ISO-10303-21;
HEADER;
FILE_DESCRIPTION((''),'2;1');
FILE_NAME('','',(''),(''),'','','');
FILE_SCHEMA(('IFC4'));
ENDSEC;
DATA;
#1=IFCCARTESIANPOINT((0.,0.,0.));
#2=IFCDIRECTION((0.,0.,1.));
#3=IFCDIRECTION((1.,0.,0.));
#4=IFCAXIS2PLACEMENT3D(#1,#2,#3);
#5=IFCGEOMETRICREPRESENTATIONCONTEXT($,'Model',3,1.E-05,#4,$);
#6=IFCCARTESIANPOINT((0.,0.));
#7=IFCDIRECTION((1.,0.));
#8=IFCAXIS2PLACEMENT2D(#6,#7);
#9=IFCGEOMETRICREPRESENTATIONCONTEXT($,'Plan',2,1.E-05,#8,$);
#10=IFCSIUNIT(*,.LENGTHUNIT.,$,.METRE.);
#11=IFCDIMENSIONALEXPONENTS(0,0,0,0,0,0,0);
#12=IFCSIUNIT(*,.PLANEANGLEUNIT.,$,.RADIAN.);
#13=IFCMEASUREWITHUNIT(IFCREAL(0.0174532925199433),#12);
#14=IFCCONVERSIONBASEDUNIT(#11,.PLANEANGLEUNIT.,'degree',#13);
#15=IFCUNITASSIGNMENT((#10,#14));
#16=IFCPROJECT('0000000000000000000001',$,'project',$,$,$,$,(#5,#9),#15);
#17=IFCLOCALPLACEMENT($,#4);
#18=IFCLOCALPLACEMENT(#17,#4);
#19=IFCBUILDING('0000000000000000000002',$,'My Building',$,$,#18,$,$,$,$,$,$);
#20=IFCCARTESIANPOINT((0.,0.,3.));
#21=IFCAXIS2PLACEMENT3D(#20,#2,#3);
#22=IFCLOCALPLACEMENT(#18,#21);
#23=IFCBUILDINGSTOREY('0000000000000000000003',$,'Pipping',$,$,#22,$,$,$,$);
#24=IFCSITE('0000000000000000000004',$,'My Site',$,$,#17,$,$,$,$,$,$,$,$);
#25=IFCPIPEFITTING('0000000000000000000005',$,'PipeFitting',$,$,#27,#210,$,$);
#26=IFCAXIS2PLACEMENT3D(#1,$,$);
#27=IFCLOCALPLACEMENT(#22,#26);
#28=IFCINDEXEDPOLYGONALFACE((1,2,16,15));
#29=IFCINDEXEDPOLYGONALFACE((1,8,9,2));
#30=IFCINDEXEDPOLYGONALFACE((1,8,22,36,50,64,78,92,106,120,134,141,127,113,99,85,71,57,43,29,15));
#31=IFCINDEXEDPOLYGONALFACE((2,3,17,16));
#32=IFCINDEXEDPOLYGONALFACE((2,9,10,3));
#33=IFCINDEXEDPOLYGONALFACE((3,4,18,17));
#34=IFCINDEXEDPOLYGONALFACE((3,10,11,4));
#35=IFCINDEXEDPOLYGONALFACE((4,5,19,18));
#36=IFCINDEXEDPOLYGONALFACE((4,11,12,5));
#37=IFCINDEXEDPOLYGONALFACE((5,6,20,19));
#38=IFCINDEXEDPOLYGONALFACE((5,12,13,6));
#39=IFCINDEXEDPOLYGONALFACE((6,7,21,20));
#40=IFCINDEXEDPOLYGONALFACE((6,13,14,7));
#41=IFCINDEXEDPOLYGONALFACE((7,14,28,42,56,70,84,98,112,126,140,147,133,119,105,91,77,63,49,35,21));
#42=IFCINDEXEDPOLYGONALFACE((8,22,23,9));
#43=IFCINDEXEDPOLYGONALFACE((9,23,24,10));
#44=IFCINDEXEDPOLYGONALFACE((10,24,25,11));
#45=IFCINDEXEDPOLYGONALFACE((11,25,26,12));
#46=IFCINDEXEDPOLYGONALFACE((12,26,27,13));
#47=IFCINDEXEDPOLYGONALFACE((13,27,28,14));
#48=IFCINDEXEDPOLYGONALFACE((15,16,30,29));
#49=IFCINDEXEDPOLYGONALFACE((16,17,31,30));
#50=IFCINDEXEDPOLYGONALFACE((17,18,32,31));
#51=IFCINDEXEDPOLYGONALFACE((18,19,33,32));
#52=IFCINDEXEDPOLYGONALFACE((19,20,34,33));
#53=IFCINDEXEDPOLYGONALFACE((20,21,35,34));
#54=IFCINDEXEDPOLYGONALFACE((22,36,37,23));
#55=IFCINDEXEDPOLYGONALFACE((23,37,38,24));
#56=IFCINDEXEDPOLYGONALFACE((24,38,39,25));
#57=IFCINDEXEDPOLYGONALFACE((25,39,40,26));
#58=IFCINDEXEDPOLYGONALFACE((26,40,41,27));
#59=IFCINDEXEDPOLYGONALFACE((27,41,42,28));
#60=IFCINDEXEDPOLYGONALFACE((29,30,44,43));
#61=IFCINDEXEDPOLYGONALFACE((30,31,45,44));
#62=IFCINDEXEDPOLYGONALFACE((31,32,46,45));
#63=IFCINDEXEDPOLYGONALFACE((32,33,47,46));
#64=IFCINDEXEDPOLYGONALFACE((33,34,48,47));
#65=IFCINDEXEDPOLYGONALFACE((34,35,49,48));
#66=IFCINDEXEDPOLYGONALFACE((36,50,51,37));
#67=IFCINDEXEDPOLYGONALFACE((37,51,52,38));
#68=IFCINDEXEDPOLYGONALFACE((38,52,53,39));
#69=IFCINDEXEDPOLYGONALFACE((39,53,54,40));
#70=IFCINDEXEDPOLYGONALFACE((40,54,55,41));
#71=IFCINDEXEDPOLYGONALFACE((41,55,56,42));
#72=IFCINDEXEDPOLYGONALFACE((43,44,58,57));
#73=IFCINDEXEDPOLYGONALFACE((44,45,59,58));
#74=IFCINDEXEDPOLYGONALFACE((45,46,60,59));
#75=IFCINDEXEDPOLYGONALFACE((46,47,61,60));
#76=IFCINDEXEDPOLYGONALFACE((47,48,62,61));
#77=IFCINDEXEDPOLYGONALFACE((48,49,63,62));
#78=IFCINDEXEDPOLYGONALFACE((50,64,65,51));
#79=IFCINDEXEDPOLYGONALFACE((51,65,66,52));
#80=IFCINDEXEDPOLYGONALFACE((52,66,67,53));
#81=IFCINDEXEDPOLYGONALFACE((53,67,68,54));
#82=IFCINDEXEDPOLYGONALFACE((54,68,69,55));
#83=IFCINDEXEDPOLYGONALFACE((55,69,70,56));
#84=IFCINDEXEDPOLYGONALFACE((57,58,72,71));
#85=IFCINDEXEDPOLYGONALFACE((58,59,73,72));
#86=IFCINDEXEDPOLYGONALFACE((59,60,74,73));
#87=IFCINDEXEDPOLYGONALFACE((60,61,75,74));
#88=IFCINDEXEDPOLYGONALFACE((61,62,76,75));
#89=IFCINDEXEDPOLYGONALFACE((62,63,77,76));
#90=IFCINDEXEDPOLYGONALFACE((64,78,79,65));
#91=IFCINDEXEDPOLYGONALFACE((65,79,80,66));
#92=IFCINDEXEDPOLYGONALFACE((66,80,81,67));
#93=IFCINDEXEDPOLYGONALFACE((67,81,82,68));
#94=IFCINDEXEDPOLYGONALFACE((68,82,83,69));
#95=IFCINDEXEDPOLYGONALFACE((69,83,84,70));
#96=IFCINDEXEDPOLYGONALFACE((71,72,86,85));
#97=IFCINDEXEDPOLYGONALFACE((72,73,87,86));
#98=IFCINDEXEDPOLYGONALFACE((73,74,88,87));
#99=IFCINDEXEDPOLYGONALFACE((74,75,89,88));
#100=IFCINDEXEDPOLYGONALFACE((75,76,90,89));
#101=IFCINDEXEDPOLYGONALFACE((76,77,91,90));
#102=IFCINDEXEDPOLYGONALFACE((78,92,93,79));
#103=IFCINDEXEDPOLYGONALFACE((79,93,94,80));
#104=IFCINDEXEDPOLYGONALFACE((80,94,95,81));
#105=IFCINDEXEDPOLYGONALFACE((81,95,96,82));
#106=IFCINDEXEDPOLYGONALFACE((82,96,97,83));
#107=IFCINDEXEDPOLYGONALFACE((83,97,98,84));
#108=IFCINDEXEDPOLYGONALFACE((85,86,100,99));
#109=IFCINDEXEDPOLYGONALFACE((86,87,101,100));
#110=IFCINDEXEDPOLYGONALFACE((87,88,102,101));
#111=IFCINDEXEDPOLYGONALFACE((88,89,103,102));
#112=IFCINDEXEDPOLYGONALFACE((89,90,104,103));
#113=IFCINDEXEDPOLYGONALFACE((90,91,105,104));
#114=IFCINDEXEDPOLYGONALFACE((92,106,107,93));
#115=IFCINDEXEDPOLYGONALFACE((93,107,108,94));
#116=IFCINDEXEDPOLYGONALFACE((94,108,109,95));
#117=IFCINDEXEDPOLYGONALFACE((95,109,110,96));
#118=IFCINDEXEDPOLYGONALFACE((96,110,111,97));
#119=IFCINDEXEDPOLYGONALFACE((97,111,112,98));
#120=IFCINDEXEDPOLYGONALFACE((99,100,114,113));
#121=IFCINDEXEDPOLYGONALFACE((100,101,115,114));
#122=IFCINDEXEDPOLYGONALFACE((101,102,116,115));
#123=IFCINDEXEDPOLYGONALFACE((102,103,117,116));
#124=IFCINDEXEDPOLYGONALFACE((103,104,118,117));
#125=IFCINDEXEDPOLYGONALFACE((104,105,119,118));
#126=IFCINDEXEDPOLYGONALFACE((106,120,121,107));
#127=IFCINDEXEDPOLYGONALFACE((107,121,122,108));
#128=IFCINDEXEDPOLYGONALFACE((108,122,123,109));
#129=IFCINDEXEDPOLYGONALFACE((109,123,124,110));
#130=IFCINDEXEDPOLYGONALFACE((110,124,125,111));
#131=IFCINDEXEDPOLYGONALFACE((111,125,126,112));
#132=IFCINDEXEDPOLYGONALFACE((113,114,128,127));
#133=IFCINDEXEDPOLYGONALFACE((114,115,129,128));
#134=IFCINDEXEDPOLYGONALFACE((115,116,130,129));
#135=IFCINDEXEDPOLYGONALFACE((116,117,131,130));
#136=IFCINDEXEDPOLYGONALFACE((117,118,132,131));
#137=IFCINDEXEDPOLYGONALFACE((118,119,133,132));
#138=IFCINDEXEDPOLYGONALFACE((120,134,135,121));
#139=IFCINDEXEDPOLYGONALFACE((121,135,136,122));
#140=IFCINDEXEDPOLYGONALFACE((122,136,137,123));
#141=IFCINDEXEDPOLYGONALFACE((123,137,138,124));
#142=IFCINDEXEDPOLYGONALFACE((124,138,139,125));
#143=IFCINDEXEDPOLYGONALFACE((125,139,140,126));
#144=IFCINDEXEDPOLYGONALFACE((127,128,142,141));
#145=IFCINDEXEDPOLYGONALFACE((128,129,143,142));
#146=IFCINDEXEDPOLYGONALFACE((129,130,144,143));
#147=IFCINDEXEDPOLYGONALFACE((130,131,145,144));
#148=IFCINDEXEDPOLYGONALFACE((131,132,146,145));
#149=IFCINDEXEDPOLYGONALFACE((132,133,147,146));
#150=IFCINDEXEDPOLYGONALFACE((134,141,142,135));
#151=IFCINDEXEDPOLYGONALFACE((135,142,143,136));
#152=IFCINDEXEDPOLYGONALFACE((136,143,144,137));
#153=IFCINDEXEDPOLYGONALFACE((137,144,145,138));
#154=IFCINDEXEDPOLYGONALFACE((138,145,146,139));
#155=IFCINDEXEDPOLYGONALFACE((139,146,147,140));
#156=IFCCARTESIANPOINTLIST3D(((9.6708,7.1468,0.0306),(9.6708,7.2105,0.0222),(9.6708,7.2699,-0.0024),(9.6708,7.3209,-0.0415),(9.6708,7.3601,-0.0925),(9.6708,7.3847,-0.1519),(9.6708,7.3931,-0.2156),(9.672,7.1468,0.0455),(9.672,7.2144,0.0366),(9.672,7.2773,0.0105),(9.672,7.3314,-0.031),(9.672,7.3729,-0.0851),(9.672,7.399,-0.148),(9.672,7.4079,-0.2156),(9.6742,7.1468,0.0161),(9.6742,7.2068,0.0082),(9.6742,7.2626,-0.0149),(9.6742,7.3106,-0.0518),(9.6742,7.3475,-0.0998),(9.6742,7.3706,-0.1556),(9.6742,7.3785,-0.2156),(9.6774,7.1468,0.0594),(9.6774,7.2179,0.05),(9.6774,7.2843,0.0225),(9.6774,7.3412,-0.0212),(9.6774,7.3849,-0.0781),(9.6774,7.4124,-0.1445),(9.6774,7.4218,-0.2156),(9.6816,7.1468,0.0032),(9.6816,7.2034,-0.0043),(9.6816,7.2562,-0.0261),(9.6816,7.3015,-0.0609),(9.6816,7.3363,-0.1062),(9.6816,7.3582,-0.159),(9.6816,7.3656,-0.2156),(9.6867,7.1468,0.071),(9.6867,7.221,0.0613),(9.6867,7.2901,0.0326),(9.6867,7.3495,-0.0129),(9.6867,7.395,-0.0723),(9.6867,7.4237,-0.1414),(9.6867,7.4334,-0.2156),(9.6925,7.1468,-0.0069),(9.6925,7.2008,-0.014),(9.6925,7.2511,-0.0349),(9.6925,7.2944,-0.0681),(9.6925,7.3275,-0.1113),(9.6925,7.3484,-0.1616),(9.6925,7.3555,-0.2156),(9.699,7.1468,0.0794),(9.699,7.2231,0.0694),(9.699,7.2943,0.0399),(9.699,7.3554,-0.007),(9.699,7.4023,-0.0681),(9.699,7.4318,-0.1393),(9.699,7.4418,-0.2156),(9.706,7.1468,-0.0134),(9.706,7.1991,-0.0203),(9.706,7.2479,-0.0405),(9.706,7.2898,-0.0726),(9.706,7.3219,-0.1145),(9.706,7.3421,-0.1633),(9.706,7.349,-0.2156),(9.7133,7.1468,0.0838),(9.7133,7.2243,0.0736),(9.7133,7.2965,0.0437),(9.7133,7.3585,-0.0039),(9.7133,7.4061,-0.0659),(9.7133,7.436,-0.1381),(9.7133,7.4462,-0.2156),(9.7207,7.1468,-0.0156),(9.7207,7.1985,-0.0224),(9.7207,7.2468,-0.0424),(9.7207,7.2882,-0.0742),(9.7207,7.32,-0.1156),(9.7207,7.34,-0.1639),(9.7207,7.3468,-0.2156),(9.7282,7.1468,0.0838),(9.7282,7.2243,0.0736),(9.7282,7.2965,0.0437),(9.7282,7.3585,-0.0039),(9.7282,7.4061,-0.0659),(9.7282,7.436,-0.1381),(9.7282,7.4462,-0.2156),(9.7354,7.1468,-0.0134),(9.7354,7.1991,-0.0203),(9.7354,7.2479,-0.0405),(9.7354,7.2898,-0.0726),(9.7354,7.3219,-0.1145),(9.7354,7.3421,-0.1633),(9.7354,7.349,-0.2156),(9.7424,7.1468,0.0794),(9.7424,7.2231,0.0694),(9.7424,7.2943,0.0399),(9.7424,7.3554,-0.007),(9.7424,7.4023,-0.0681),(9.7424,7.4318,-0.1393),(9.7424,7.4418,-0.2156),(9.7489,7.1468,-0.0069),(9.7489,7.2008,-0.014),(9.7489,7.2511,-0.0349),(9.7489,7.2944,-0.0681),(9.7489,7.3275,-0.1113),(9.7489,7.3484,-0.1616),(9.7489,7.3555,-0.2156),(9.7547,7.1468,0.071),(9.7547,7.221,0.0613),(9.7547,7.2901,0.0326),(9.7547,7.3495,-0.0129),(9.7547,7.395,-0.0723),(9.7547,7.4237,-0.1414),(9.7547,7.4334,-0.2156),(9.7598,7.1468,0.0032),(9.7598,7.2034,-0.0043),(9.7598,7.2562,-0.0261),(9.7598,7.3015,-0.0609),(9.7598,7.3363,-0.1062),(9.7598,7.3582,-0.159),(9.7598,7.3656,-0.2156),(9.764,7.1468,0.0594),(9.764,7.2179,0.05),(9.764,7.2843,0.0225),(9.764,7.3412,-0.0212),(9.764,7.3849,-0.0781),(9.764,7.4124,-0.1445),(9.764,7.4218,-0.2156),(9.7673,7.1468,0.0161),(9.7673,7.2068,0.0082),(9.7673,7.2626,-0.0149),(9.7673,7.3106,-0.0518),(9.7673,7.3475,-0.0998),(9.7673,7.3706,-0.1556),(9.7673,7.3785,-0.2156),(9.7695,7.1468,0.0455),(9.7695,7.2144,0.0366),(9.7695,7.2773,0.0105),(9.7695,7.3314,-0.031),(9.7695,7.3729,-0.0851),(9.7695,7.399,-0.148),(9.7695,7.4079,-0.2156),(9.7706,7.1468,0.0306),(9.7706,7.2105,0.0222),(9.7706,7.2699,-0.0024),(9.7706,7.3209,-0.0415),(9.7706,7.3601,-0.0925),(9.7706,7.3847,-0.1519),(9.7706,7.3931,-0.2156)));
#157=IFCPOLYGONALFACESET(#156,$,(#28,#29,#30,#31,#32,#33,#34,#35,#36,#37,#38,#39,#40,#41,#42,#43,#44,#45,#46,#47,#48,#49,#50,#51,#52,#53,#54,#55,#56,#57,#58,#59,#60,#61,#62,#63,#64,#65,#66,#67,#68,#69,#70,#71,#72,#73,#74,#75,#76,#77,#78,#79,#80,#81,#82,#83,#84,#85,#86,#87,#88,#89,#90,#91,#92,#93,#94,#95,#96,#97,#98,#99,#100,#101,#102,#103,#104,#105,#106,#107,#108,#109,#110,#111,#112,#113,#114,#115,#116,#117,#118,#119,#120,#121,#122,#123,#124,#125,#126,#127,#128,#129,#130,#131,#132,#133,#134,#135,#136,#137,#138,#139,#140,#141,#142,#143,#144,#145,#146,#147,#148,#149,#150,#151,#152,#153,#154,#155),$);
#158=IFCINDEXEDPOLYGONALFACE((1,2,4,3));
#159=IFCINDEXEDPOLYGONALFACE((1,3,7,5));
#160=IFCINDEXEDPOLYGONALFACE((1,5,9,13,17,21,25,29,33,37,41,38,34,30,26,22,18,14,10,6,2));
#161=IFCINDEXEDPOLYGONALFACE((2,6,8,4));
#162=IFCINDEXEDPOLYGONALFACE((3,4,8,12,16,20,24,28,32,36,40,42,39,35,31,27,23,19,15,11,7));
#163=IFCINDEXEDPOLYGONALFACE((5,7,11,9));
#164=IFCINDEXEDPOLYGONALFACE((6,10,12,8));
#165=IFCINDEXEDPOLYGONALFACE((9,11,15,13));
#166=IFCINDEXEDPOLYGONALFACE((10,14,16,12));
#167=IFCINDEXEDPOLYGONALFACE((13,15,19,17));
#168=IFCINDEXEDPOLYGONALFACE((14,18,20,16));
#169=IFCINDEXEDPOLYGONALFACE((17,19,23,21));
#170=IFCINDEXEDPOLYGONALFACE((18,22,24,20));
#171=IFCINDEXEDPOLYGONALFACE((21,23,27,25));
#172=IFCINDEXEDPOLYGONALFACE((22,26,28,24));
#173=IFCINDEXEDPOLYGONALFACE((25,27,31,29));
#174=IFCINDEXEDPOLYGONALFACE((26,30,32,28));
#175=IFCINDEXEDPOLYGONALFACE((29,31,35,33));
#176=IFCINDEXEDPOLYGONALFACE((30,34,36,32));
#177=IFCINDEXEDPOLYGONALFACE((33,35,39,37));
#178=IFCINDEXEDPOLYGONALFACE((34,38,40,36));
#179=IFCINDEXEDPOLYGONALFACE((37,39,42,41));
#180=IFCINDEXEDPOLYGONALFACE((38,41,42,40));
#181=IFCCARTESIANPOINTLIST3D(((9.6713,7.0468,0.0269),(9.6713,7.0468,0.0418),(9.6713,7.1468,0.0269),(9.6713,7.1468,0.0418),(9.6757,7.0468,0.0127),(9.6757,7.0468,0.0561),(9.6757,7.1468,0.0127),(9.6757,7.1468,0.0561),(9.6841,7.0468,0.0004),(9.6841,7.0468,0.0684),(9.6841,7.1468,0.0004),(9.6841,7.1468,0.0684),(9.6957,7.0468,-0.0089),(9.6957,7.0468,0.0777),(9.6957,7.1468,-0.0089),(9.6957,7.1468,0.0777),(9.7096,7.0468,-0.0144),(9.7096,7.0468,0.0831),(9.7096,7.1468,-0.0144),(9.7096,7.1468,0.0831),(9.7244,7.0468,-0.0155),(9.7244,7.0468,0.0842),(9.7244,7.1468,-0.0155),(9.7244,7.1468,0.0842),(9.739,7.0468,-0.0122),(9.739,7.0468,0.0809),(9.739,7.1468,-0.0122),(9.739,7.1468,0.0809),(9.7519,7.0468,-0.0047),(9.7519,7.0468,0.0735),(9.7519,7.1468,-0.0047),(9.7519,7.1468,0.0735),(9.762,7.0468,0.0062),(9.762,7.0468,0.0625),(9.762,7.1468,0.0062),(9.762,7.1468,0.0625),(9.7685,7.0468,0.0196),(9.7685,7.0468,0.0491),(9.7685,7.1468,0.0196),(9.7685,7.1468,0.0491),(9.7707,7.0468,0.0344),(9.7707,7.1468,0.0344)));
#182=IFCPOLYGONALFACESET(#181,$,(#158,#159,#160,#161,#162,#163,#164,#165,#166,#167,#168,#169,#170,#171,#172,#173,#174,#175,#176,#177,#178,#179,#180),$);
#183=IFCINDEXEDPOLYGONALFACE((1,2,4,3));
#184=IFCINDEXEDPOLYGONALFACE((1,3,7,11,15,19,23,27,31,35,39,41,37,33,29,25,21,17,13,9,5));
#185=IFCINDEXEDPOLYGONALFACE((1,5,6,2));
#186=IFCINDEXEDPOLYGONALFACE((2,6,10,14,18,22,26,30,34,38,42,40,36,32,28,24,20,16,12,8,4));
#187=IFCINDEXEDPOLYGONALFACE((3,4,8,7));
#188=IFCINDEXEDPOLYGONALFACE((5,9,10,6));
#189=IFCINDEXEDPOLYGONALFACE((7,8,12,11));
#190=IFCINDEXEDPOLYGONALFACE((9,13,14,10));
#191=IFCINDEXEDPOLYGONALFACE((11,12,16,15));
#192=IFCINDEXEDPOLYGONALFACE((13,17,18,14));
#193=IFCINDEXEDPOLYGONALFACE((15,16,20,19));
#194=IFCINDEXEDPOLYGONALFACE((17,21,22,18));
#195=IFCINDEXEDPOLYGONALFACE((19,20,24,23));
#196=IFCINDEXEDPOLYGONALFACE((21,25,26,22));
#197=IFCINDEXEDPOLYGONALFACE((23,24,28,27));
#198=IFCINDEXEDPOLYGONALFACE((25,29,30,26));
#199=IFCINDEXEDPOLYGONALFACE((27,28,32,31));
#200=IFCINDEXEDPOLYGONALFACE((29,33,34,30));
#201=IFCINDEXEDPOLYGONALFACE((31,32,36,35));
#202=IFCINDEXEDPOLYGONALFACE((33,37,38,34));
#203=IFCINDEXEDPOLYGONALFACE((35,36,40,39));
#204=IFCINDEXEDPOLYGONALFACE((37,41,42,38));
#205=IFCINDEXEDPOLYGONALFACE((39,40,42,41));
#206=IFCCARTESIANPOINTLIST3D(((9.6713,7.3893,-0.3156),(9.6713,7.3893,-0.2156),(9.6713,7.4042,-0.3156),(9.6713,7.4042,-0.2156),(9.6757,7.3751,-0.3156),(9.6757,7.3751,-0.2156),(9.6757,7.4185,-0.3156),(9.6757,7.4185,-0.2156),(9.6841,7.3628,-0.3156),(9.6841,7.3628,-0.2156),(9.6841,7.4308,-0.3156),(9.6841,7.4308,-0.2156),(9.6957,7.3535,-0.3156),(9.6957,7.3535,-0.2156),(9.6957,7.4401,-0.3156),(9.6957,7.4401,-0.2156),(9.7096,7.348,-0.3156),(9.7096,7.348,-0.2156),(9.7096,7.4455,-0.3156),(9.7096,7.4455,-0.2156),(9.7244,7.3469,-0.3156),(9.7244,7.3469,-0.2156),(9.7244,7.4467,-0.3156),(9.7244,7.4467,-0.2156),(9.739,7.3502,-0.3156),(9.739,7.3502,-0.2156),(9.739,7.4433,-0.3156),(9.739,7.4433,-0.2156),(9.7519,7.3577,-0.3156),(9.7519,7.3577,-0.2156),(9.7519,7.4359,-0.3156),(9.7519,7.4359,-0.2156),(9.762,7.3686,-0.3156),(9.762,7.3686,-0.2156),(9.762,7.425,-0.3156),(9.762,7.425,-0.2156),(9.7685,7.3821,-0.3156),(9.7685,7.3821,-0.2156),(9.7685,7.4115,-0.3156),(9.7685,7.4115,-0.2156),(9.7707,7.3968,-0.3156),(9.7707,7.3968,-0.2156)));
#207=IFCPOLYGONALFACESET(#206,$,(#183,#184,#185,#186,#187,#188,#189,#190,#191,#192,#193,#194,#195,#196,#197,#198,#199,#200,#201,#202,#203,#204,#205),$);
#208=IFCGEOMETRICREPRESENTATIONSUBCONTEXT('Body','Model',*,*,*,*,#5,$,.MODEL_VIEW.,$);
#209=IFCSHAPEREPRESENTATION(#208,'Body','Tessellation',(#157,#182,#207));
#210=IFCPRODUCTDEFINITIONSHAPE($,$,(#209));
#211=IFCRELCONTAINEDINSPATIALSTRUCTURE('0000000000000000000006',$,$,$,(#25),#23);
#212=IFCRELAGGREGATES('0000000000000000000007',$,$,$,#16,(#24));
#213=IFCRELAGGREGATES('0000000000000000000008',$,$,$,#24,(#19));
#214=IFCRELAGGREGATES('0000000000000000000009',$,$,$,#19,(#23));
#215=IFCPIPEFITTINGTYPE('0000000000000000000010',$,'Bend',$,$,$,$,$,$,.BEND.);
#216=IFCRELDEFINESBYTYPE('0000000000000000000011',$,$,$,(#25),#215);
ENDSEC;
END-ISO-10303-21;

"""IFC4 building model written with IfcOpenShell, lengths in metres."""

from ifc_helpers import new_model, entity, si_unit, converted_unit, frame, origin_with_axes, origin_2d_with_axis, place, context, subcontext, project, spatial, circle, extrude, source, transform, mapped, type_object, type_shapes, element, save


model = new_model("IFC4")

# Units and contexts
model_context = context("Model", 3, precision=1e-05, world=origin_with_axes())
plan_context = context("Plan", 2, precision=1e-05, world=origin_2d_with_axis())
body_context = subcontext(model_context, "Body", "Model", "MODEL_VIEW")
ifc_project = project(units=[si_unit("LENGTHUNIT", "METRE"), converted_unit("PLANEANGLEUNIT", "degree", entity("IfcReal", 0.0174532925199433), si_unit("PLANEANGLEUNIT", "RADIAN"), dimensions=[0, 0, 0, 0, 0, 0, 0])], contexts=[model_context, plan_context])

# Site, building, storey
site_placement = place(None, origin_with_axes())
site = spatial("IfcSite", under=ifc_project, at=site_placement, Name="My Site")
building_placement = place(site_placement, origin_with_axes())
building = spatial("IfcBuilding", under=site, at=building_placement, Name="My Building")
storey_placement = place(building_placement, frame((0.0, 0.0, 3.0), z_axis=(0.0, 0.0, 1.0), x_axis=(1.0, 0.0, 0.0)))
storey = spatial("IfcBuildingStorey", under=building, at=storey_placement, Name="Pipping")

# Pipe fitting
pipe_fitting_type_1 = type_object("IfcPipeFittingType", Name="Bend", PredefinedType="BEND")
shared_shape_1 = source(origin_with_axes(), body_context, "Body", "SolidModel", [
    entity("IfcSweptDiskSolid", entity("IfcIndexedPolyCurve", entity("IfcCartesianPointList3D", [[0.0, 0.0, 0.1], [0.0, 0.0732, 0.2768], [0.0, 0.25, 0.35]]), [entity("IfcArcIndex", [1, 2, 3])]), 0.05),
    extrude(circle(Radius=0.05), origin_with_axes(), (0.0, 0.0, 1.0), 0.1),
    extrude(circle(Radius=0.05), frame((0.0, 0.25, 0.35), z_axis=(0.0, 1.0, -0.000073), x_axis=(1.0, 0.0, 0.0)), (0.0, 0.0, 1.0), 0.1),
])
type_shapes(pipe_fitting_type_1, [shared_shape_1])
for number, where, z_axis, x_axis, name in (
    (1, (9.7207, 7.0468, 0.0344), (0.0, 1.0, 0.000073), (1.0, 0.0, 0.0), "PipeFitting"),
):
    element("IfcPipeFitting", number, at=place(storey_placement, frame(where, z_axis=z_axis, x_axis=x_axis)), inside=storey, type_object=pipe_fitting_type_1, Name=name, context=body_context, shape_type="MappedRepresentation", body=[
        mapped(shared_shape_1, transform((0.0, 0.0, 0.0), x_axis=(1.0, 0.0, 0.0), y_axis=(0.0, 1.0, 0.0), z_axis=(0.0, 0.0, 1.0), scale=1.0)),
    ])

save(model, "model.ifc")
